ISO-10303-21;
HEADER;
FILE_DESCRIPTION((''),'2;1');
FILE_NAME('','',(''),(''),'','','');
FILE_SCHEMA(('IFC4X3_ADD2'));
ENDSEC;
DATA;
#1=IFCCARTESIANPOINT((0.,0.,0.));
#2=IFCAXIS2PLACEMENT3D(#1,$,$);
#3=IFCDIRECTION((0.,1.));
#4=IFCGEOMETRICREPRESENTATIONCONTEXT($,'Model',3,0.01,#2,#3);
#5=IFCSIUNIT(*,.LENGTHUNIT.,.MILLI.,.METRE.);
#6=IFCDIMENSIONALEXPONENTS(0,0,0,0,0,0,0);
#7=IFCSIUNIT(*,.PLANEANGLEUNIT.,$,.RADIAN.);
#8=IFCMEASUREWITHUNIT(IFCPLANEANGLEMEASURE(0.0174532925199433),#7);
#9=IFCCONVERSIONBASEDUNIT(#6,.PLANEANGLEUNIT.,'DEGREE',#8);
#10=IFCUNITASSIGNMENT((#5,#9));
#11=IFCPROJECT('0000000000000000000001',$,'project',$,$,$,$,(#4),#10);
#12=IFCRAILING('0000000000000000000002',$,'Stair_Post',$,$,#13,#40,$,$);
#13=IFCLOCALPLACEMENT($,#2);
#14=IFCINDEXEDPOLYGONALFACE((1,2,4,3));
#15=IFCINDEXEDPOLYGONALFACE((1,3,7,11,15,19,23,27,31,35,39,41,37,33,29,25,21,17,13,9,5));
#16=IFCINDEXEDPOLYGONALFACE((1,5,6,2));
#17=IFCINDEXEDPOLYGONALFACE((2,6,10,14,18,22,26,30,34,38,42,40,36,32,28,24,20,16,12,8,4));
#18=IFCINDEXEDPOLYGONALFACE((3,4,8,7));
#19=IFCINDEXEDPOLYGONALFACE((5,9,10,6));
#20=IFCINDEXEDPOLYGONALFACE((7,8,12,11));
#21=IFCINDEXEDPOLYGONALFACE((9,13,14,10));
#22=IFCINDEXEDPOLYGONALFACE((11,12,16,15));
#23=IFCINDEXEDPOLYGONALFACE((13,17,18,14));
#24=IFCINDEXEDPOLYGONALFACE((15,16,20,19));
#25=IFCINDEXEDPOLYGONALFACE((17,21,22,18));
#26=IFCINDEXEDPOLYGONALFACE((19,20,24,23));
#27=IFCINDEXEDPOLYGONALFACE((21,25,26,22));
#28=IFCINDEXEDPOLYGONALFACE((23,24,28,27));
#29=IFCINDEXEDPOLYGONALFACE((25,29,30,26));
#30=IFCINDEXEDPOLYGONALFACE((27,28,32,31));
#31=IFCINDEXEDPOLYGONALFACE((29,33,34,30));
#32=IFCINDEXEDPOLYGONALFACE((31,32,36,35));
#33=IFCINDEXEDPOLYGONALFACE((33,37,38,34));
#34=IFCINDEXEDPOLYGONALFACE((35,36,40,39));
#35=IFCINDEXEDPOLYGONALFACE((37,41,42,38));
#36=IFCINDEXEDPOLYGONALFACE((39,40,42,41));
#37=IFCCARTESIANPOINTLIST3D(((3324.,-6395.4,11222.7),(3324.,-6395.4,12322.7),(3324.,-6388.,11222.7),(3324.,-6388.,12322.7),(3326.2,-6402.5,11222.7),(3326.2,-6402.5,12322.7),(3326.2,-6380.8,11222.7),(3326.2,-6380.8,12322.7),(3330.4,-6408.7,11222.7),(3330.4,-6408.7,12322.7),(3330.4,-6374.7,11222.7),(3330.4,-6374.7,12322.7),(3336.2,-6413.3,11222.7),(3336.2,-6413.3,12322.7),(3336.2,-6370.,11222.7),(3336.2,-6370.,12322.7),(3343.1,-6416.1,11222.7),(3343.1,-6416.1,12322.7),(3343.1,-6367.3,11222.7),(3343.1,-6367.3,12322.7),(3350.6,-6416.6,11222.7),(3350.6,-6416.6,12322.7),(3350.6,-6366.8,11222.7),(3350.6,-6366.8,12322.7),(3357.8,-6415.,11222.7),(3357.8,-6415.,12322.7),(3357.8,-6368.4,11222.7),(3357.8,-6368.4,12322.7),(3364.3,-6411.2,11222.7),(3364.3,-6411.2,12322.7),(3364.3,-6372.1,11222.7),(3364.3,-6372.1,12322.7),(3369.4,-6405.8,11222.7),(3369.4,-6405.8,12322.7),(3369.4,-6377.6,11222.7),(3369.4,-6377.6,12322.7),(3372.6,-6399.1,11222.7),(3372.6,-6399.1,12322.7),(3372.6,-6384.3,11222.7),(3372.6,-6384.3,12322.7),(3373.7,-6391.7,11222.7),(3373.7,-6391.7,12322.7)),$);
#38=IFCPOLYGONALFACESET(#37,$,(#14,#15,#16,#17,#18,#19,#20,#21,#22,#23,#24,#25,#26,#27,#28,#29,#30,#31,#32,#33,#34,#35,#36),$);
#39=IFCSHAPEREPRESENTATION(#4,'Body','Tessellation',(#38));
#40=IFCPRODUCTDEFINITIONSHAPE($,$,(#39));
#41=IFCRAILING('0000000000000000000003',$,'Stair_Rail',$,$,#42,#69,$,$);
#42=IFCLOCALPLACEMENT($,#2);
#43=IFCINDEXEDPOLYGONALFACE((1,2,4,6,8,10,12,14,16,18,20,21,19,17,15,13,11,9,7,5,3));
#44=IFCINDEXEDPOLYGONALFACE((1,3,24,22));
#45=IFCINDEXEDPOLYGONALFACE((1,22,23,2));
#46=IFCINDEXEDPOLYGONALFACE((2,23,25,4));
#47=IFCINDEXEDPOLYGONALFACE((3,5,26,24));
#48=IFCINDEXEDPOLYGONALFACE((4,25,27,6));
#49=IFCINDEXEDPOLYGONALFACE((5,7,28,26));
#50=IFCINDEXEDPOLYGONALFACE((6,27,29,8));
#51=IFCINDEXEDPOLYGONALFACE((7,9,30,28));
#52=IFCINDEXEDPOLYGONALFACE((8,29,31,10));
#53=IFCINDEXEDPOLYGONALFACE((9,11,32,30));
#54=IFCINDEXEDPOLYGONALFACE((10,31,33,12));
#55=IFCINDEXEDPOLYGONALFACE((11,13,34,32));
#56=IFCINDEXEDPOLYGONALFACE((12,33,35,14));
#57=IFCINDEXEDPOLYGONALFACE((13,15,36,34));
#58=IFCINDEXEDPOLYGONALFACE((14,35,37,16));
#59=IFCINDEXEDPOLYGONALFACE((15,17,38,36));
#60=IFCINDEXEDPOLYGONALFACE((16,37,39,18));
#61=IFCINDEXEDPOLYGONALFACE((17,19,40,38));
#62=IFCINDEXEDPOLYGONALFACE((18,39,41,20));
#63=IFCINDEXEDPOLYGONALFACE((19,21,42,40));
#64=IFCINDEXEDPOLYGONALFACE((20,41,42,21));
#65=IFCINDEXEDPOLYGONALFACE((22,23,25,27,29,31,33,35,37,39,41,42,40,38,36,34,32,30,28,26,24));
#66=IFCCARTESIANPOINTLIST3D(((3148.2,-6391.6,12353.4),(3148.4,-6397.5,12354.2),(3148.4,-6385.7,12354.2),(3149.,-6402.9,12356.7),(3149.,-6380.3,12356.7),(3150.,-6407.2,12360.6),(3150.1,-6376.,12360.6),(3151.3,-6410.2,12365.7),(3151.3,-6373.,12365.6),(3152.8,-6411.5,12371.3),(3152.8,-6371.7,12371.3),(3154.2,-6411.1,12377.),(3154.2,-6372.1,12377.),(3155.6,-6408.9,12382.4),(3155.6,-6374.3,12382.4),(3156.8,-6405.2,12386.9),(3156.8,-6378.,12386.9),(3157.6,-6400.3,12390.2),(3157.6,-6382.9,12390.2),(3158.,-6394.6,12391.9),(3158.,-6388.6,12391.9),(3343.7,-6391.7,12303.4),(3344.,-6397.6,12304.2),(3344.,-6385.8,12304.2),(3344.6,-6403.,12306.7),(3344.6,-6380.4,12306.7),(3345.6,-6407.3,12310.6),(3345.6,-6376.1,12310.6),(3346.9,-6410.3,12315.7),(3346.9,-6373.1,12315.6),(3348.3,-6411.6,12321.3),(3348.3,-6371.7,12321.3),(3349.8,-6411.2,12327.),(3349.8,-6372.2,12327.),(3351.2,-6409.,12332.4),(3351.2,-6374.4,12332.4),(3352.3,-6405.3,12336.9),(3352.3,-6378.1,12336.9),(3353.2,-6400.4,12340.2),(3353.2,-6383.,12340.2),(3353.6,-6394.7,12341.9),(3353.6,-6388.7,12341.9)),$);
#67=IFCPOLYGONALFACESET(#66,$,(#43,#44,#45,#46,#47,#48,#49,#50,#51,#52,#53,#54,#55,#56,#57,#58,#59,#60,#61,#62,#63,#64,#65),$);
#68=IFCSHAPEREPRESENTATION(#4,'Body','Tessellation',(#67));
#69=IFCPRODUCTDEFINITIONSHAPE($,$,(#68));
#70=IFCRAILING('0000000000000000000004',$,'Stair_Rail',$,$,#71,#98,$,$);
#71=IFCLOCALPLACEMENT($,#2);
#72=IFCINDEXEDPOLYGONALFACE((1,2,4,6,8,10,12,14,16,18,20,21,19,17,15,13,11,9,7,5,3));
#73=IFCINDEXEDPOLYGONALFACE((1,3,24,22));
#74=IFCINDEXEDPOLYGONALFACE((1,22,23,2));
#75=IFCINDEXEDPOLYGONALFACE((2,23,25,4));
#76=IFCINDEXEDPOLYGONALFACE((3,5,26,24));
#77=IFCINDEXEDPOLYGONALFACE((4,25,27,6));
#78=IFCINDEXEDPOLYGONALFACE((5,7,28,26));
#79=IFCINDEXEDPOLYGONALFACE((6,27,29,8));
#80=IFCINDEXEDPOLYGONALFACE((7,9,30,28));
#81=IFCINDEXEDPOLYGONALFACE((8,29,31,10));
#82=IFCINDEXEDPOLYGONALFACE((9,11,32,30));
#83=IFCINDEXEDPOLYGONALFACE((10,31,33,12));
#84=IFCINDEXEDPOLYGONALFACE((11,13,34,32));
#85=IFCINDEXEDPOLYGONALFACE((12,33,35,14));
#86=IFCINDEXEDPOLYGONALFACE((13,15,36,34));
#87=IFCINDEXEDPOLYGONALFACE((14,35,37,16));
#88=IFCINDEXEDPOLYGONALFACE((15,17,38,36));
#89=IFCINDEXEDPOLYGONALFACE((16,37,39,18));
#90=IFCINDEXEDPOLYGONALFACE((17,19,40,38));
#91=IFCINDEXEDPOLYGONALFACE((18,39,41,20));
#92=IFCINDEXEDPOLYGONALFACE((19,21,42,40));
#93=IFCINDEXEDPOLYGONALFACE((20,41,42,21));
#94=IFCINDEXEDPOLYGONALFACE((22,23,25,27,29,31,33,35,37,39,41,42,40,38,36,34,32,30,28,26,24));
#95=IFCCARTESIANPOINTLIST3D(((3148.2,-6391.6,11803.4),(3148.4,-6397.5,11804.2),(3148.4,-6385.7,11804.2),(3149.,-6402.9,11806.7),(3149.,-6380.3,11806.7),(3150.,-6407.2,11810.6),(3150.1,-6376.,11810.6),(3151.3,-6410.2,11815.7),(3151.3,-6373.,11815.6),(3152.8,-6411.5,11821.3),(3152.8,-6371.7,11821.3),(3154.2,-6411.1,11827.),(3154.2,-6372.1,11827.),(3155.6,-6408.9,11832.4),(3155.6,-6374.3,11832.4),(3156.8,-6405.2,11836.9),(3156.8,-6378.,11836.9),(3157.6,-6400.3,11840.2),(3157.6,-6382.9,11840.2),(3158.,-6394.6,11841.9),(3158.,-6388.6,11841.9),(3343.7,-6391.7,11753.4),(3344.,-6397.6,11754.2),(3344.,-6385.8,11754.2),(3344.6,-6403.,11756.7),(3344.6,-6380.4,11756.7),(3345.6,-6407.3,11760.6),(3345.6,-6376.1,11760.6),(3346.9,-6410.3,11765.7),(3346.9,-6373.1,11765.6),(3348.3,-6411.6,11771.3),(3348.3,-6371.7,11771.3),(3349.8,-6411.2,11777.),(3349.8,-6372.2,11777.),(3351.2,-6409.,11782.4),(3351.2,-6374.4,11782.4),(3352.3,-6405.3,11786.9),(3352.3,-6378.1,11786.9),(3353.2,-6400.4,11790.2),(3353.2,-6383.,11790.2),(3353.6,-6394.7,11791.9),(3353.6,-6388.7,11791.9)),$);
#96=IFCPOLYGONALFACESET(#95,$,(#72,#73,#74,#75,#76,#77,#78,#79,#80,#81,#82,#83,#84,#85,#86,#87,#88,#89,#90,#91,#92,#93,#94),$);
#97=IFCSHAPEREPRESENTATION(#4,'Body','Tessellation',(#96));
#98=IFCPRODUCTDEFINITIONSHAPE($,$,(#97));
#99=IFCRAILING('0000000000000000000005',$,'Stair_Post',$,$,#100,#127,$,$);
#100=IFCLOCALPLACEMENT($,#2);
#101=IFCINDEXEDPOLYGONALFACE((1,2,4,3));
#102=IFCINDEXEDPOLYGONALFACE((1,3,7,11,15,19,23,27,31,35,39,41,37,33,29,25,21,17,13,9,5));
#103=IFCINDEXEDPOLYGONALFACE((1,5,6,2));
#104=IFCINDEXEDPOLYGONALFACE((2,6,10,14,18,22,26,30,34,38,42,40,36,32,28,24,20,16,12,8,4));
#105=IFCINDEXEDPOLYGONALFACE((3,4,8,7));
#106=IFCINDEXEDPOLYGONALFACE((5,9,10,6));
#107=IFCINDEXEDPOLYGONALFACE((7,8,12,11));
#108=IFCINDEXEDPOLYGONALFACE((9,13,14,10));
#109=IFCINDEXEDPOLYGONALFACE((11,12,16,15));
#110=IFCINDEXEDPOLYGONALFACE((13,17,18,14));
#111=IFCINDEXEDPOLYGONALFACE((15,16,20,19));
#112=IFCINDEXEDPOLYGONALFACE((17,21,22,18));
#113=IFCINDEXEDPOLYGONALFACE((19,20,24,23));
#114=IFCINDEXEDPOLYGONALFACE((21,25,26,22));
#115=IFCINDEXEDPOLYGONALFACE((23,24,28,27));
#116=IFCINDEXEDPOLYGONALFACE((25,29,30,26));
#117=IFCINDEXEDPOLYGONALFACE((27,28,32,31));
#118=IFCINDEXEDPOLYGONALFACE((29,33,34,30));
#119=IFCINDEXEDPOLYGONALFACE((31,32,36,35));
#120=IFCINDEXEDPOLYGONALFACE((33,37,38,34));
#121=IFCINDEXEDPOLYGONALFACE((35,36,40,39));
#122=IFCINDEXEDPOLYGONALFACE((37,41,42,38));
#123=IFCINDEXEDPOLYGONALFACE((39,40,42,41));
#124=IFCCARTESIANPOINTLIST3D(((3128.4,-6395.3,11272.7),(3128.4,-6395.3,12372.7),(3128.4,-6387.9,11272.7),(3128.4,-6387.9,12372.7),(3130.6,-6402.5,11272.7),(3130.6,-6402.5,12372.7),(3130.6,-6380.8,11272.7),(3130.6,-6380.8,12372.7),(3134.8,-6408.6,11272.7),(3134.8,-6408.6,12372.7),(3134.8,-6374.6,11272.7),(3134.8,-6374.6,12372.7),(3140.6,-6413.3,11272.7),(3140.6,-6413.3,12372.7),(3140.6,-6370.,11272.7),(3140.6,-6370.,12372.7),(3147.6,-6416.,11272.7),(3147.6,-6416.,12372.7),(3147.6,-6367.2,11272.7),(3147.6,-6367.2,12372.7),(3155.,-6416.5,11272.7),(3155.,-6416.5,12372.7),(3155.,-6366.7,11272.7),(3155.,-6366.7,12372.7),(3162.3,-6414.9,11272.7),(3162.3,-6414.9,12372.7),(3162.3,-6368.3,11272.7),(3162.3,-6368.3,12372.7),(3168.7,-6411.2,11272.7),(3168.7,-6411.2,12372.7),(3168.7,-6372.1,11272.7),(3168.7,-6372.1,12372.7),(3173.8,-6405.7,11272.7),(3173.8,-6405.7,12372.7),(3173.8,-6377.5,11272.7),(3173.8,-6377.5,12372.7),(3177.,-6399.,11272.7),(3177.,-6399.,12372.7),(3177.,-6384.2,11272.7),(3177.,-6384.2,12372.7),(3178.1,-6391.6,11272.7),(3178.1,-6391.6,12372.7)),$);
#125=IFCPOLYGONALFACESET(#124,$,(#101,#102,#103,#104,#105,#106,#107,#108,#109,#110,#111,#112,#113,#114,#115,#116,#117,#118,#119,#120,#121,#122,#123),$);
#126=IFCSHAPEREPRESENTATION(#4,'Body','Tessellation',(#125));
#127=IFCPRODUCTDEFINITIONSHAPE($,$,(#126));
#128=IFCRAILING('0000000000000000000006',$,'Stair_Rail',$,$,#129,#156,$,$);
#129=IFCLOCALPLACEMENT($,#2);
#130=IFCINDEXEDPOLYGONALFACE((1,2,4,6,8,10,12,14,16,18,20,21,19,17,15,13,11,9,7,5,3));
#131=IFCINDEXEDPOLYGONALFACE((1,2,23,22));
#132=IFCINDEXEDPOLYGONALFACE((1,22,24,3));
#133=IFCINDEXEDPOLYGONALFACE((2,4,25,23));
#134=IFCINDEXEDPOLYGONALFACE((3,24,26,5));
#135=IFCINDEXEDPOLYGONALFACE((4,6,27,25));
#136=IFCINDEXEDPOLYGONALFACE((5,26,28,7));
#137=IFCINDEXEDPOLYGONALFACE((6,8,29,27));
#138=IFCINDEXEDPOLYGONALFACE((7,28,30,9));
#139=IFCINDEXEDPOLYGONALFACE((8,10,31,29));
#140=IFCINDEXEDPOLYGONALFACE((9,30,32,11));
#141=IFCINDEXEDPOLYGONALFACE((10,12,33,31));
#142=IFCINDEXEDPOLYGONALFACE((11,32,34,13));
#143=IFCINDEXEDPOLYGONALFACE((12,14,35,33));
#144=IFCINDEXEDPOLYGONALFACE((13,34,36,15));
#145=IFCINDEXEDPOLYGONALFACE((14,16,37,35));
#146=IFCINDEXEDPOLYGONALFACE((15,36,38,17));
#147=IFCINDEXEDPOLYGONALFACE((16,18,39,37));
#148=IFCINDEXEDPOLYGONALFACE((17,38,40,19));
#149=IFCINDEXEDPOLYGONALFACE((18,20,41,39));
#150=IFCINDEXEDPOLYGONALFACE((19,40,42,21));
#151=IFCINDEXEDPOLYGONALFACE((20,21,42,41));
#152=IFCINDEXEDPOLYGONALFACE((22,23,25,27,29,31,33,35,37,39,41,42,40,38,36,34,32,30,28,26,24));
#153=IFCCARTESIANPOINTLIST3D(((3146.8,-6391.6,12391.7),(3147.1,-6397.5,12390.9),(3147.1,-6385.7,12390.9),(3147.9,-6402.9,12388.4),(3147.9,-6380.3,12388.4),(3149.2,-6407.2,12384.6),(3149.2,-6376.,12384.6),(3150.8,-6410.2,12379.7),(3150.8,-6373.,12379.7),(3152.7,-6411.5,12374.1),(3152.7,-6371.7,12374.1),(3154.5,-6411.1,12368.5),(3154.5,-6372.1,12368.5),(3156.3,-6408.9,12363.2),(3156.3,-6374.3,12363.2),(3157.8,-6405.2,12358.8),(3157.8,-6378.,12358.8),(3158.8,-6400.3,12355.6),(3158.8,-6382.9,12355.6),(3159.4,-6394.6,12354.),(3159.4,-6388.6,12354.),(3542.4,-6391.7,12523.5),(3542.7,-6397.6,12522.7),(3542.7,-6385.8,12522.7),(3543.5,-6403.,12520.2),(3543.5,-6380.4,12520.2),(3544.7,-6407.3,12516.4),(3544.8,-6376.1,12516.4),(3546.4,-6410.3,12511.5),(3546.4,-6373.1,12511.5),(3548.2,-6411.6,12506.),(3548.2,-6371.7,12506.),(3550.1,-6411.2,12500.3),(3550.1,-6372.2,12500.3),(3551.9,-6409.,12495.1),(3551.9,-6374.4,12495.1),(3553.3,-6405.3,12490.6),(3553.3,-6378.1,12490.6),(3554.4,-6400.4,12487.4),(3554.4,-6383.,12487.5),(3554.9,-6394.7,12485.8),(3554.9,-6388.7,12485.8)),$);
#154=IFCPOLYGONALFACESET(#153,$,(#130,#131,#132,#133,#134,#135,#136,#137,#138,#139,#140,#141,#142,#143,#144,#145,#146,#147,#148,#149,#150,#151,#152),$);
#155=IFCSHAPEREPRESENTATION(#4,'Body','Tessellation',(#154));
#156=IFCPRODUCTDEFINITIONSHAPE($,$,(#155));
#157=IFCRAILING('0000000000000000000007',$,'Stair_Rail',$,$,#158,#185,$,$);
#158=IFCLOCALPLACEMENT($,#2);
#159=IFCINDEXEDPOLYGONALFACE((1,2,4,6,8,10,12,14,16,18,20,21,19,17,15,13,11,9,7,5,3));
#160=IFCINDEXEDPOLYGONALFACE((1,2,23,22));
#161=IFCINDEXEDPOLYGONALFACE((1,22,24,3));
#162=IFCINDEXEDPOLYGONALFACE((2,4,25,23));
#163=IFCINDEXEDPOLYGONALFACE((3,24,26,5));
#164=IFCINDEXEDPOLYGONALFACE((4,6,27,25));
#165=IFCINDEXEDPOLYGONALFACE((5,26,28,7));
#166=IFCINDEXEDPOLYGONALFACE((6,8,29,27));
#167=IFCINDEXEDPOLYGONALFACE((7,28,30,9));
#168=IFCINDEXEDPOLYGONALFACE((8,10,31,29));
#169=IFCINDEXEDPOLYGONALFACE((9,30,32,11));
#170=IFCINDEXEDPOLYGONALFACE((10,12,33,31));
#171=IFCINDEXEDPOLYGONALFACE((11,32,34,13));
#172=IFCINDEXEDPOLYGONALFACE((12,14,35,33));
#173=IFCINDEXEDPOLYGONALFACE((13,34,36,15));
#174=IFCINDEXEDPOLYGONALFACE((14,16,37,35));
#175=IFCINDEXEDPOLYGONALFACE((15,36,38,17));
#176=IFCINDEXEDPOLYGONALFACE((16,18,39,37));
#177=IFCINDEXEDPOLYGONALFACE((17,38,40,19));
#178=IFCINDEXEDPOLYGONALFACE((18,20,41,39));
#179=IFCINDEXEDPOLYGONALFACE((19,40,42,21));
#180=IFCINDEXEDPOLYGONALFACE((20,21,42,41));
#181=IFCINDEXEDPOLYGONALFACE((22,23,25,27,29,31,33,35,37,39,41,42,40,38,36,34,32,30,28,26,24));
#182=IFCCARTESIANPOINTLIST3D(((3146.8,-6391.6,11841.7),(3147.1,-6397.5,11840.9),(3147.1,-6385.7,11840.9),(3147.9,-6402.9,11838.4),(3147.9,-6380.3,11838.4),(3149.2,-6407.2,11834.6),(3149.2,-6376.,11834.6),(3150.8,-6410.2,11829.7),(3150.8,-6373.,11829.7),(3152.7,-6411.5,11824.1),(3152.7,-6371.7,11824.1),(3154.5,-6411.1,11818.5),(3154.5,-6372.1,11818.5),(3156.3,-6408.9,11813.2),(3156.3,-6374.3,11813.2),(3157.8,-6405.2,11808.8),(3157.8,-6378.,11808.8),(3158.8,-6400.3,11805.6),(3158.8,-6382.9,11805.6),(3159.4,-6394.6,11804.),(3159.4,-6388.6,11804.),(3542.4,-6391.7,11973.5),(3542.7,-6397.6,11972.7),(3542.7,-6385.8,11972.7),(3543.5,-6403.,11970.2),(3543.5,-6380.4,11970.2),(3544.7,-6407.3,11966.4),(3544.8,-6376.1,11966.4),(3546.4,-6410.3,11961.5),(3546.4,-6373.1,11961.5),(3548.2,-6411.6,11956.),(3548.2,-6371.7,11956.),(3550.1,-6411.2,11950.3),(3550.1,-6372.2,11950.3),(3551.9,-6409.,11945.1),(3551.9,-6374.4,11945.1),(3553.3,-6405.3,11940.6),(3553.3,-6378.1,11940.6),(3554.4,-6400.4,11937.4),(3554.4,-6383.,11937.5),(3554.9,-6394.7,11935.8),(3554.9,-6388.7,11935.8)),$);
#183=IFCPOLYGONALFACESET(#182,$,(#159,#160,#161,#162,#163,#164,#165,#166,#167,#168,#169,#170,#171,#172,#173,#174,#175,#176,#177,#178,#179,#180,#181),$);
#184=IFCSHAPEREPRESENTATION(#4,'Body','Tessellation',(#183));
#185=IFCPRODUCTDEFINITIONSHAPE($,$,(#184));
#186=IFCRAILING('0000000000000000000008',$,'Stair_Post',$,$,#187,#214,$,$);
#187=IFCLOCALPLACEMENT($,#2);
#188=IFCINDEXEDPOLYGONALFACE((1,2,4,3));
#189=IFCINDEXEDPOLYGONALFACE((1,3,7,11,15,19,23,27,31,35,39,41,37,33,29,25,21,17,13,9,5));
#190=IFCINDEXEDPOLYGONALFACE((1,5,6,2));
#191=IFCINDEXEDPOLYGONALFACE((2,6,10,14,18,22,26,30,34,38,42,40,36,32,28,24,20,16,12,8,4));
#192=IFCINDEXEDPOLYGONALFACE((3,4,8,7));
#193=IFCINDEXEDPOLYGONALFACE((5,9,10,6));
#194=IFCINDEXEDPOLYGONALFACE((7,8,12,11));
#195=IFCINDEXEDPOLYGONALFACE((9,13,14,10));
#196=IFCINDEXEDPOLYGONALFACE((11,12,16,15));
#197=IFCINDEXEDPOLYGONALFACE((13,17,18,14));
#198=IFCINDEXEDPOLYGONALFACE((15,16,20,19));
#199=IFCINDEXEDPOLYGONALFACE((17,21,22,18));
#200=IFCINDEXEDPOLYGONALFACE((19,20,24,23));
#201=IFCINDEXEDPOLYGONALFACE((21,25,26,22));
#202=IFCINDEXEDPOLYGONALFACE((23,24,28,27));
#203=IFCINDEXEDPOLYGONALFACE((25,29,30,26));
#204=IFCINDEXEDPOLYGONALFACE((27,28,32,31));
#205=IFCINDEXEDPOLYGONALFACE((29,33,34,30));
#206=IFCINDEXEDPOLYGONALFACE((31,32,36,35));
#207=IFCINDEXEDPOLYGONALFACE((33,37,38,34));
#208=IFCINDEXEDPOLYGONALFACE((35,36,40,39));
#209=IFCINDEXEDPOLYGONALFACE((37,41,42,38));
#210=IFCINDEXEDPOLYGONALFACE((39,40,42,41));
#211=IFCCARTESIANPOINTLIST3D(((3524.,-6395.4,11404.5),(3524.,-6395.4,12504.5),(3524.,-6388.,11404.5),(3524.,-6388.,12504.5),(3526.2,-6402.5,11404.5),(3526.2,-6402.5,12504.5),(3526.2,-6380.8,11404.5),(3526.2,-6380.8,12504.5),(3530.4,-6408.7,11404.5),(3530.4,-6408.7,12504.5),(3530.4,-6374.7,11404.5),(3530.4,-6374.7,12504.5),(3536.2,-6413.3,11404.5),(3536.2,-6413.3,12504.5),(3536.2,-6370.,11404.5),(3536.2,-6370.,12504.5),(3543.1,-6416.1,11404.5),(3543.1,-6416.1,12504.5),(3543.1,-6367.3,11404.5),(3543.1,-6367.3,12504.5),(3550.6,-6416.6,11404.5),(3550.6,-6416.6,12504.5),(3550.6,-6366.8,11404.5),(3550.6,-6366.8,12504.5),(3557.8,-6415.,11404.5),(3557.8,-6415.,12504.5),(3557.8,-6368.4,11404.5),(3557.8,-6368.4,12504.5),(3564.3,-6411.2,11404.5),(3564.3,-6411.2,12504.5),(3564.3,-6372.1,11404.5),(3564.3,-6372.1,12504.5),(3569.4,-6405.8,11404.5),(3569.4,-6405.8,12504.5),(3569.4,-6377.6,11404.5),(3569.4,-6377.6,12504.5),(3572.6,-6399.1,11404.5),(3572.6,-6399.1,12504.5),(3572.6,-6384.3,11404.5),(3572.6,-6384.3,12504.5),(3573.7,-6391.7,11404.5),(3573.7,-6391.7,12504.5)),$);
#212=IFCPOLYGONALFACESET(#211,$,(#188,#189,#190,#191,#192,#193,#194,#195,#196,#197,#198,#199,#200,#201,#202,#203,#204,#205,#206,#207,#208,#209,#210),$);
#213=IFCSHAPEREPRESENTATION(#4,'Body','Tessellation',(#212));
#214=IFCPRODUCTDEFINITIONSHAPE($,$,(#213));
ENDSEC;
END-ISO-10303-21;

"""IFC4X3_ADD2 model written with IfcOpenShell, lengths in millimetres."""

from ifc_helpers import new_model, entity, si_unit, converted_unit, direction, frame, origin, context, project, circle, extrude, element, save


model = new_model("IFC4X3_ADD2")

# Units and contexts
model_context = context("Model", 3, precision=0.01, world=origin(), true_north=direction((0.0, 1.0)))
ifc_project = project(units=[si_unit("LENGTHUNIT", "METRE", prefix="MILLI"), converted_unit("PLANEANGLEUNIT", "DEGREE", entity("IfcPlaneAngleMeasure", 0.0174532925199433), si_unit("PLANEANGLEUNIT", "RADIAN"), dimensions=[0, 0, 0, 0, 0, 0, 0])], contexts=[model_context])

# Railings
element("IfcRailing", 1, Name="Stair_Post", context=model_context, shape_type="SweptSolid", body=[
    extrude(circle(Radius=25.0), frame((3348.7, -6391.7, 11222.7)), (0.0, 0.0, 1.0), 1100.0),
])
element("IfcRailing", 2, Name="Stair_Rail", context=model_context, shape_type="SweptSolid", body=[
    entity("IfcSweptDiskSolid", entity("IfcPolyline", [entity("IfcCartesianPoint", [3348.7, -6391.7, 12322.7]), entity("IfcCartesianPoint", [3153.1, -6391.6, 12372.7])]), 20.0),
])
element("IfcRailing", 3, Name="Stair_Rail", context=model_context, shape_type="SweptSolid", body=[
    entity("IfcSweptDiskSolid", entity("IfcPolyline", [entity("IfcCartesianPoint", [3348.7, -6391.7, 11772.7]), entity("IfcCartesianPoint", [3153.1, -6391.6, 11822.7])]), 20.0),
])
element("IfcRailing", 4, Name="Stair_Post", context=model_context, shape_type="SweptSolid", body=[
    extrude(circle(Radius=25.0), frame((3153.1, -6391.6, 11272.7)), (0.0, 0.0, 1.0), 1100.0),
])
element("IfcRailing", 5, Name="Stair_Rail", context=model_context, shape_type="SweptSolid", body=[
    entity("IfcSweptDiskSolid", entity("IfcPolyline", [entity("IfcCartesianPoint", [3153.1, -6391.6, 12372.7]), entity("IfcCartesianPoint", [3548.7, -6391.7, 12504.5])]), 20.0),
])
element("IfcRailing", 6, Name="Stair_Rail", context=model_context, shape_type="SweptSolid", body=[
    entity("IfcSweptDiskSolid", entity("IfcPolyline", [entity("IfcCartesianPoint", [3153.1, -6391.6, 11822.7]), entity("IfcCartesianPoint", [3548.7, -6391.7, 11954.5])]), 20.0),
])
element("IfcRailing", 7, Name="Stair_Post", context=model_context, shape_type="SweptSolid", body=[
    extrude(circle(Radius=25.0), frame((3548.7, -6391.7, 11404.5)), (0.0, 0.0, 1.0), 1100.0),
])

save(model, "model.ifc")
